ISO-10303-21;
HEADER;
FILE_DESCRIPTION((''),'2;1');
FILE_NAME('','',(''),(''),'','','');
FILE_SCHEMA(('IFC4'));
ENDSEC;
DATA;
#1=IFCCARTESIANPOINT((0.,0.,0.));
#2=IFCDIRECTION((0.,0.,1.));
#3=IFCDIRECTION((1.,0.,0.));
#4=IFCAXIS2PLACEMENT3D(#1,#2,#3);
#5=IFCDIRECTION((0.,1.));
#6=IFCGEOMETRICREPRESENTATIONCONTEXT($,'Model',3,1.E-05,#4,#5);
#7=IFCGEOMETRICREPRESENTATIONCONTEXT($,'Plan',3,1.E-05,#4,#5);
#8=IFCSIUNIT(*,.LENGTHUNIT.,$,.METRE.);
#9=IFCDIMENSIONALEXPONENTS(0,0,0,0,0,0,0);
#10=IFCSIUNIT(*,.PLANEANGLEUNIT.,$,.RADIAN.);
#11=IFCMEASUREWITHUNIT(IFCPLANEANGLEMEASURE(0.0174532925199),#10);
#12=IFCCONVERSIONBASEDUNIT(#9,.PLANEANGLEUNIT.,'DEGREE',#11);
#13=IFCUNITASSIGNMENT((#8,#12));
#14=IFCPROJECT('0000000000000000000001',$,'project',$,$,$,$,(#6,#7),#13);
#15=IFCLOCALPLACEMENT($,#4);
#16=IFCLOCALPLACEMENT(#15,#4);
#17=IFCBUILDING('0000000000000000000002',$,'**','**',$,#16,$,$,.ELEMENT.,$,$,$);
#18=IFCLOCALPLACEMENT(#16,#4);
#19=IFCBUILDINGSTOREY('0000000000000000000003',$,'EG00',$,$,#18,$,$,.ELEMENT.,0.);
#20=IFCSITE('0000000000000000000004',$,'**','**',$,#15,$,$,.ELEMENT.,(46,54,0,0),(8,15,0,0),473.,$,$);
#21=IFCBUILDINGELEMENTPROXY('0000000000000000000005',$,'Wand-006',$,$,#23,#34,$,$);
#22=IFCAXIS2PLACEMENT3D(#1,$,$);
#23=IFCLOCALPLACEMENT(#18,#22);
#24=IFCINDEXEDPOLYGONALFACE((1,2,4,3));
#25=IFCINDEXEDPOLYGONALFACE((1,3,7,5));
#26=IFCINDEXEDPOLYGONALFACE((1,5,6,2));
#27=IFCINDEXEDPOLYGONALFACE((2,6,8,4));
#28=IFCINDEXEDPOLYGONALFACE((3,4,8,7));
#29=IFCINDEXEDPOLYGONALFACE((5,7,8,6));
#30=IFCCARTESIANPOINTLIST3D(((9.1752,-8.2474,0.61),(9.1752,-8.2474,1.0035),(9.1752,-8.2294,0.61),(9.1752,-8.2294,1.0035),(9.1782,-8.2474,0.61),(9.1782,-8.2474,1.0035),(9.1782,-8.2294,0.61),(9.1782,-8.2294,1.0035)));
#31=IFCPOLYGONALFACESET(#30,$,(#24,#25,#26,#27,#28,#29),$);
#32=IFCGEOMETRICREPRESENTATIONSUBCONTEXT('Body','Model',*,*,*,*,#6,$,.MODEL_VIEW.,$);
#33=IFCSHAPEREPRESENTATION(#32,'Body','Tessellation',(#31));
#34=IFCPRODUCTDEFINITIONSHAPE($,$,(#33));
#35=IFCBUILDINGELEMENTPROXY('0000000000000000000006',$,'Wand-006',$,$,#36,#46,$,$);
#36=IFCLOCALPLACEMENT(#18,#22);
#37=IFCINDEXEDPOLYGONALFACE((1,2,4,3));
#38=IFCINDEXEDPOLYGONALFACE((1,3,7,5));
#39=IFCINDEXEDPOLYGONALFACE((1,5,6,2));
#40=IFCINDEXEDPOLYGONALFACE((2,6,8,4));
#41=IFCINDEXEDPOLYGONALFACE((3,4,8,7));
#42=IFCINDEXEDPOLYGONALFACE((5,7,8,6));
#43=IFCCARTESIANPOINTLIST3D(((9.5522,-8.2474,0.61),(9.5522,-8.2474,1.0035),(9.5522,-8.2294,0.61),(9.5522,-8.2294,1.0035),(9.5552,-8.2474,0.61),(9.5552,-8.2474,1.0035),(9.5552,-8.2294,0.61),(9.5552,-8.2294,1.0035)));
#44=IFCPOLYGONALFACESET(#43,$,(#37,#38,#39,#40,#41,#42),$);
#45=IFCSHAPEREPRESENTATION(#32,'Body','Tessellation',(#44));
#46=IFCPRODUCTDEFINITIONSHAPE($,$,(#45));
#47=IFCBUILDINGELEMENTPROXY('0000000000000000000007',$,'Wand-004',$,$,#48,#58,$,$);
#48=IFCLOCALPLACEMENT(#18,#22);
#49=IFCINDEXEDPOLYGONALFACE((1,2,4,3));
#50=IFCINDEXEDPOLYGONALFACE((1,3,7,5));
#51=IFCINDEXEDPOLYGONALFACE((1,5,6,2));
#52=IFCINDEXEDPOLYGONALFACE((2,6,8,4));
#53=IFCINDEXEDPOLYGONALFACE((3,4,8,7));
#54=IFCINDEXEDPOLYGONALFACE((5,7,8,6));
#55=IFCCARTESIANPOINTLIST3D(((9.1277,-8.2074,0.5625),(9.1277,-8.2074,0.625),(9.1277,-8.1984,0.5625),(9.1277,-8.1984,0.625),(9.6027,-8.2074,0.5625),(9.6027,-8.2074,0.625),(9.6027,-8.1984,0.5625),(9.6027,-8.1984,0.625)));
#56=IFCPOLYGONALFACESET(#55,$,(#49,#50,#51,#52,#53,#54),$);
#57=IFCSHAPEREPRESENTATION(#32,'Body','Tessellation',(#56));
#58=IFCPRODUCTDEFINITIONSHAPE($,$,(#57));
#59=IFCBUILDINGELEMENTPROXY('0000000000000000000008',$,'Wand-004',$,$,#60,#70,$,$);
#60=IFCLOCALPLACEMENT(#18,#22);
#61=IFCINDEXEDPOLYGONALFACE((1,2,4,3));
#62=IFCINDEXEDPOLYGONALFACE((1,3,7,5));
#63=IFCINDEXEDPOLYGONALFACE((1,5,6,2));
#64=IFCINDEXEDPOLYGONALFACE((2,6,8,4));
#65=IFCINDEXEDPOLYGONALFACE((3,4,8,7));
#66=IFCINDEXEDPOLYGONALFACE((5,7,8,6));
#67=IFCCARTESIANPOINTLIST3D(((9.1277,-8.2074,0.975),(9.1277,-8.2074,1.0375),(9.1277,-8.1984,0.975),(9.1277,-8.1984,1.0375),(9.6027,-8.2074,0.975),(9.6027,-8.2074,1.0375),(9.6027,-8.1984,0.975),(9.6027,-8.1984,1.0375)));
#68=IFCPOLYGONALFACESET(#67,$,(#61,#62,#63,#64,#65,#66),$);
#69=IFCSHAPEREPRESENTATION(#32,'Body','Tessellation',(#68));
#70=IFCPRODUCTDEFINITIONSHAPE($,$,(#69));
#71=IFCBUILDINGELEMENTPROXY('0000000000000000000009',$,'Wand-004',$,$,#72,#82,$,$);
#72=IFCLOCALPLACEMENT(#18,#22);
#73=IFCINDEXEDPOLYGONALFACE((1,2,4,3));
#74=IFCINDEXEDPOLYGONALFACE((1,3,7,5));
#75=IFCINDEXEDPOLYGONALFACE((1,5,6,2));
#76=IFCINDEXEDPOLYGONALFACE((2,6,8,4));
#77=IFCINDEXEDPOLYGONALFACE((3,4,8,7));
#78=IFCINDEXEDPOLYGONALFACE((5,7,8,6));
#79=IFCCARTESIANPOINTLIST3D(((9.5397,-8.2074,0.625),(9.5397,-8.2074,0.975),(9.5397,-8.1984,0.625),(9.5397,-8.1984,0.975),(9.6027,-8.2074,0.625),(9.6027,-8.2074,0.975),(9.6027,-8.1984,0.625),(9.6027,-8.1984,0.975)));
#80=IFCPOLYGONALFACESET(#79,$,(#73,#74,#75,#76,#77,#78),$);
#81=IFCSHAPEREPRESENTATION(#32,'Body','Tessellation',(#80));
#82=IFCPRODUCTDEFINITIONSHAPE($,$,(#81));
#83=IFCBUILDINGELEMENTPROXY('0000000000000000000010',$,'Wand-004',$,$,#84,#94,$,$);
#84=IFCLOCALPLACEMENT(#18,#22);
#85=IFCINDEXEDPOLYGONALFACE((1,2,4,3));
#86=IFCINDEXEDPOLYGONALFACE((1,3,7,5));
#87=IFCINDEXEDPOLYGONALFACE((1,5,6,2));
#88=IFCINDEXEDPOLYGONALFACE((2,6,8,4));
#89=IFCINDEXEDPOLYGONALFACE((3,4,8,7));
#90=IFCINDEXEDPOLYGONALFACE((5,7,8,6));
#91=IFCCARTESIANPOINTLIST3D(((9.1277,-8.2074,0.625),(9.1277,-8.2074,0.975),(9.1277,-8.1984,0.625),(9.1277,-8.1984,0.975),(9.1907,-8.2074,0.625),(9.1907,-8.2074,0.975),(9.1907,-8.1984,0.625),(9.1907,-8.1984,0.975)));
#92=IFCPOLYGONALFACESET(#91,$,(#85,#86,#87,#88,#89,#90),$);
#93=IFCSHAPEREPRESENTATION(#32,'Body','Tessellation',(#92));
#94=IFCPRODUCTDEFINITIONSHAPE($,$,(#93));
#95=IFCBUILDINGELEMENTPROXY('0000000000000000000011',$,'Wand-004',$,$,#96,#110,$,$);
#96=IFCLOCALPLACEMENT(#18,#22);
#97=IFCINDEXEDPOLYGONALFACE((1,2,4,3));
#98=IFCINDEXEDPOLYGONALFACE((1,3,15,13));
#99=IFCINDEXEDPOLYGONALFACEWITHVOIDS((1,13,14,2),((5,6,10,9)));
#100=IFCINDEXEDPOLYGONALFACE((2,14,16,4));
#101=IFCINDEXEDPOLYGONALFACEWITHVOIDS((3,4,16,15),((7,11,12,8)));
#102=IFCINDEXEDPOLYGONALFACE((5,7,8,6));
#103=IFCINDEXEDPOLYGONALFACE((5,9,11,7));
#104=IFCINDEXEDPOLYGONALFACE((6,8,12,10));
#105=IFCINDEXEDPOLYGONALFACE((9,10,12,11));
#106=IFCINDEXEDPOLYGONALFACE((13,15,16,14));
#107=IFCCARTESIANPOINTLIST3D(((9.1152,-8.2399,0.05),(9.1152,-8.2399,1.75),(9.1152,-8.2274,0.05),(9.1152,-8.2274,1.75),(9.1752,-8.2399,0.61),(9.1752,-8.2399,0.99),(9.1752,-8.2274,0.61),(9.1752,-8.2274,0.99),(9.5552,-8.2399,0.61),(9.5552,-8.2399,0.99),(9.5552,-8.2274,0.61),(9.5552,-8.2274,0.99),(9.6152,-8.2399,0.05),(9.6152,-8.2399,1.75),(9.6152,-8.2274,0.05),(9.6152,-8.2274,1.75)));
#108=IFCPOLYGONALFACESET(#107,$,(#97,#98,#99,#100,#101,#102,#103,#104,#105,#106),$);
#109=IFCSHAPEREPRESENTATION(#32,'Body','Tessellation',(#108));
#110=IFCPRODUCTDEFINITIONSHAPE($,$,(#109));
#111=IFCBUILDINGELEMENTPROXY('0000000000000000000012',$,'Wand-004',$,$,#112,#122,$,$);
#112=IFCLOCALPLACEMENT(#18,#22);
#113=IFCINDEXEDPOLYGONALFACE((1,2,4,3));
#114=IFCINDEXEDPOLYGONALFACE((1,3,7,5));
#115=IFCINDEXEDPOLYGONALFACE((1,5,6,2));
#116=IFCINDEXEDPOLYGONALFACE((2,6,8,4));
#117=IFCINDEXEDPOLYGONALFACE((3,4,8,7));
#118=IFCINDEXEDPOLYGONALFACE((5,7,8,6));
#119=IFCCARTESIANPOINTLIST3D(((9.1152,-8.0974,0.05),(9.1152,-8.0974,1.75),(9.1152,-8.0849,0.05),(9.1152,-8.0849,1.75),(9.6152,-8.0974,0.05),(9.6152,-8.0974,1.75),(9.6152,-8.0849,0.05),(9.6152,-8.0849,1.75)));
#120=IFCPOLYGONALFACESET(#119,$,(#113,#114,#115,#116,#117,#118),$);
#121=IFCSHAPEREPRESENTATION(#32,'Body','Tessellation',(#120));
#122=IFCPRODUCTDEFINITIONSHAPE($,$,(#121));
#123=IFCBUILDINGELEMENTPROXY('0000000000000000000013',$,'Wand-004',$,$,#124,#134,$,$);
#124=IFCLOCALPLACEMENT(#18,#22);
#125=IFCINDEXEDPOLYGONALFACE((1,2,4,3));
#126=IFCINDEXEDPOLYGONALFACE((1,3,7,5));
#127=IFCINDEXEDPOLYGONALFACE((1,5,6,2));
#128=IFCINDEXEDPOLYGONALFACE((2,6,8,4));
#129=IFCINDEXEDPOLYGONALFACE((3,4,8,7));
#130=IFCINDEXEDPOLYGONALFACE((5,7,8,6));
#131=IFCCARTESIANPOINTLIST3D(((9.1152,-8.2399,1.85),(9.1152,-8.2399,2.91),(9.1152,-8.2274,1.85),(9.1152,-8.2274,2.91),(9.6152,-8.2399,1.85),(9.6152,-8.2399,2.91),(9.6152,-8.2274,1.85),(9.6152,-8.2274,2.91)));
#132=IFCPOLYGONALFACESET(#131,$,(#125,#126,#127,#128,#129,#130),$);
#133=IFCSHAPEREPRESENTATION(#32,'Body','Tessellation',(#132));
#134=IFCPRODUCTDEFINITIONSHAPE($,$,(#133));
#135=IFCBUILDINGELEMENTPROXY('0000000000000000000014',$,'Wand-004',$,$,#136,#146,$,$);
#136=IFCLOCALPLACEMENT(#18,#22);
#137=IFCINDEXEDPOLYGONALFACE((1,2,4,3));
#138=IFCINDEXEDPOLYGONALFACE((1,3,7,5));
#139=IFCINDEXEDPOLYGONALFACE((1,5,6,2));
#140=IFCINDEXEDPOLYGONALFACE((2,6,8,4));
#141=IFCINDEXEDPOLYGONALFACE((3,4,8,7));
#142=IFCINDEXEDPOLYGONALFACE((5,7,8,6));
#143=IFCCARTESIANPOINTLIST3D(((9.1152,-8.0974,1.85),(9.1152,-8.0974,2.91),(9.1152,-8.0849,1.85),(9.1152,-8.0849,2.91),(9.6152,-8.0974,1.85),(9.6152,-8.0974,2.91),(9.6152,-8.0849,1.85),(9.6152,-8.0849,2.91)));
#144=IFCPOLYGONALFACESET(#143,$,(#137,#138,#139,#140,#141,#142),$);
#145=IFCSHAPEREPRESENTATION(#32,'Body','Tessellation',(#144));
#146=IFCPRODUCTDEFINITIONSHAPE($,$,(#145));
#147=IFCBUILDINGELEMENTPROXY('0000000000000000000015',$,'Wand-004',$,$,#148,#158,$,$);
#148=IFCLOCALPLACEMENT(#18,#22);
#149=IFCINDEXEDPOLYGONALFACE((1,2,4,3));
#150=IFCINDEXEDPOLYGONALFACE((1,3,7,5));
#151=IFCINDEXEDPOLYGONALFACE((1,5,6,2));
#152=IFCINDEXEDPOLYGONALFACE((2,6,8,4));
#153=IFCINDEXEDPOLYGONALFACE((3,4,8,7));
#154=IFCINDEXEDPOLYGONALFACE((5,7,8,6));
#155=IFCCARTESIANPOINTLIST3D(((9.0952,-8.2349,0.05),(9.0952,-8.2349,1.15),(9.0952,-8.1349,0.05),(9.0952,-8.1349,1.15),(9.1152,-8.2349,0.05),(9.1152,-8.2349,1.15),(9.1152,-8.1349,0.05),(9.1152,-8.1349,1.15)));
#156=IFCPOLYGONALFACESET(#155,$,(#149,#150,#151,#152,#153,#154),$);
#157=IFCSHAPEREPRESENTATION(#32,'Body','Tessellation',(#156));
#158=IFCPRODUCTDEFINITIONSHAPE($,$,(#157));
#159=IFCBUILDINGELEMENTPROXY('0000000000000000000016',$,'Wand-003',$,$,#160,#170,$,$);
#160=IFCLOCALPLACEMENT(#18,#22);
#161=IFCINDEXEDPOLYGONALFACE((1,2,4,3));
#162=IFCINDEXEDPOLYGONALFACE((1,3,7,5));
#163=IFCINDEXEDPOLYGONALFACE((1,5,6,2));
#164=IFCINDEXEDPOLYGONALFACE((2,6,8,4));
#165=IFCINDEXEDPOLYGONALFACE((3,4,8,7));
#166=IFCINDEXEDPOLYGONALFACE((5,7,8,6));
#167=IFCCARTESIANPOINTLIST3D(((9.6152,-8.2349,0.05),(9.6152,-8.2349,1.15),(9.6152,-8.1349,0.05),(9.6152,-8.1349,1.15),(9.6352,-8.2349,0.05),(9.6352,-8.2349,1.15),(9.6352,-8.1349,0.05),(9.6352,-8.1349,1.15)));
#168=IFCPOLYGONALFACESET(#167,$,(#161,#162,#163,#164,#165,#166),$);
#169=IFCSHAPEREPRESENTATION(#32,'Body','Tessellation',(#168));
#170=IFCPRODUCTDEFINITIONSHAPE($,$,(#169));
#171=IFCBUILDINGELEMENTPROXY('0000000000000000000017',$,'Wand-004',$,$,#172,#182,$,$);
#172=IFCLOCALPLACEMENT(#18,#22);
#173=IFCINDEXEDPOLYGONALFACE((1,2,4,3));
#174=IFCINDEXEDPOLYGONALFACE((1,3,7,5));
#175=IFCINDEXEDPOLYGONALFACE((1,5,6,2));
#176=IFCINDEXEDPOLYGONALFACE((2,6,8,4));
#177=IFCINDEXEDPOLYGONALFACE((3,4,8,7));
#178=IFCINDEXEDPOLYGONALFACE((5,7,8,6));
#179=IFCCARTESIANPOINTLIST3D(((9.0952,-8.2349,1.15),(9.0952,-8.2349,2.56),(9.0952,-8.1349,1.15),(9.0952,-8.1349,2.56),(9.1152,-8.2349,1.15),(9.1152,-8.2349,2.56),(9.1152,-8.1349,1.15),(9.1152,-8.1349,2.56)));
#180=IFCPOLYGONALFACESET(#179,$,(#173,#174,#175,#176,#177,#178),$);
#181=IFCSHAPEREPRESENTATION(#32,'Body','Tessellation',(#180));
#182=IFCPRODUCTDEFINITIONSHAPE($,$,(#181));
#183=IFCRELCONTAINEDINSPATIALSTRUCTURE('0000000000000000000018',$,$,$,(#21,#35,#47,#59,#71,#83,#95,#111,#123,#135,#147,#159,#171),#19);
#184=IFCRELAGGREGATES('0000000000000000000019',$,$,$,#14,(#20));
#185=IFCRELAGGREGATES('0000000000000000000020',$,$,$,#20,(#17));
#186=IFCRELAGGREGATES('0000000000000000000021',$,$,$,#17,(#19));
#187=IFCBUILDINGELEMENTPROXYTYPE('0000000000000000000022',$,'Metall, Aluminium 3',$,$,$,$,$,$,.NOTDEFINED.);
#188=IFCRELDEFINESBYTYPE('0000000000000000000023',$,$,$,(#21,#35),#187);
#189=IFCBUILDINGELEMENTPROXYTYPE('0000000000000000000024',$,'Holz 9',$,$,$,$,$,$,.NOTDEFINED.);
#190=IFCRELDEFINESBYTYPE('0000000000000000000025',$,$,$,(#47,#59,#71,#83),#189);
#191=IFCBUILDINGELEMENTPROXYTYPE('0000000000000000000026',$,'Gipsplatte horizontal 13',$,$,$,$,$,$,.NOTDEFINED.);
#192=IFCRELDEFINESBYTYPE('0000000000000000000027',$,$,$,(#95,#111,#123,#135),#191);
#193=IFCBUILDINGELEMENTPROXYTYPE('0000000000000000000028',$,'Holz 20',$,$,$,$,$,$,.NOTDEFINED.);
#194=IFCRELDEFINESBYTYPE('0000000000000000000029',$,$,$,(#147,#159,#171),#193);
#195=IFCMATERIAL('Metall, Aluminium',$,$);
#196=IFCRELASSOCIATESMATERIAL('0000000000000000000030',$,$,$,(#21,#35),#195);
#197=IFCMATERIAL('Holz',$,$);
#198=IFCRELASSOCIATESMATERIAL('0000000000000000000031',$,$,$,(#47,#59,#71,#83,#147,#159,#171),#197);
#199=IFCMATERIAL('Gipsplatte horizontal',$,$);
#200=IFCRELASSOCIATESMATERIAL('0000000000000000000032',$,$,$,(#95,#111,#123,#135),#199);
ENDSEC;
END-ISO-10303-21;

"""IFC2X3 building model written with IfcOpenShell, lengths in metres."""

from ifc_helpers import new_model, entity, si_unit, converted_unit, direction, frame, origin_with_axes, origin_2d_with_axis, place, context, subcontext, project, spatial, polyline, rectangle, outline, extrude, material, type_object, element, save


model = new_model("IFC2X3")

# Units and contexts
model_context = context("Model", 3, precision=1e-05, world=origin_with_axes(), true_north=direction((0.0, 1.0)))
plan_context = context("Plan", 3, precision=1e-05, world=origin_with_axes(), true_north=direction((0.0, 1.0)))
body_context = subcontext(model_context, "Body", "Model", "MODEL_VIEW")
ifc_project = project(units=[si_unit("LENGTHUNIT", "METRE"), converted_unit("PLANEANGLEUNIT", "DEGREE", entity("IfcPlaneAngleMeasure", 0.0174532925199), si_unit("PLANEANGLEUNIT", "RADIAN"), dimensions=[0, 0, 0, 0, 0, 0, 0])], contexts=[model_context, plan_context])

# Site, building, storey
site_placement = place(None, origin_with_axes())
site = spatial("IfcSite", under=ifc_project, at=site_placement, Name="**", Description="**", CompositionType="ELEMENT", RefLatitude=(46, 54, 0, 0), RefLongitude=(8, 15, 0, 0), RefElevation=473.0)
building_placement = place(site_placement, origin_with_axes())
building = spatial("IfcBuilding", under=site, at=building_placement, Name="**", Description="**", CompositionType="ELEMENT")
storey_placement = place(building_placement, origin_with_axes())
storey = spatial("IfcBuildingStorey", under=building, at=storey_placement, Name="EG00", CompositionType="ELEMENT", Elevation=0.0)

# Building element proxies
ifc_material_1 = material(Name="Holz")
ifc_material_2 = material(Name="Metall, Aluminium")
building_element_proxy_type_1 = type_object("IfcBuildingElementProxyType", Name="Metall, Aluminium 3", PredefinedType="NOTDEFINED")
proxy_1_placement = place(storey_placement, frame((9.1752, -8.2294, 0.61), z_axis=(0.0, 0.0, 1.0), x_axis=(0.0, -1.0, 0.0)))
element("IfcBuildingElementProxy", 1, at=proxy_1_placement, inside=storey, type_object=building_element_proxy_type_1, material=ifc_material_2, Name="Wand-006", context=body_context, shape_type="SweptSolid", body=[
    extrude(outline(polyline([(0.0, 0.0), (0.018, 0.0), (0.018, 0.003), (0.0, 0.003), (0.0, 0.0)])), origin_with_axes(), (0.0, 0.0, 1.0), 0.3935),
])
proxy_2_placement = place(storey_placement, frame((9.5552, -8.2294, 0.61), z_axis=(0.0, 0.0, 1.0), x_axis=(0.0, -1.0, 0.0)))
element("IfcBuildingElementProxy", 2, at=proxy_2_placement, inside=storey, type_object=building_element_proxy_type_1, material=ifc_material_2, Name="Wand-006", context=body_context, shape_type="SweptSolid", body=[
    extrude(outline(polyline([(0.0, -0.003), (0.018, -0.003), (0.018, 0.0), (0.0, 0.0), (0.0, -0.003)])), origin_with_axes(), (0.0, 0.0, 1.0), 0.3935),
])
building_element_proxy_type_2 = type_object("IfcBuildingElementProxyType", Name="Holz 9", PredefinedType="NOTDEFINED")
for number, where, z_axis, x_axis, name in (
    (3, (9.6027, -8.2074, 0.5625), (0.0, 0.0, 1.0), (-1.0, 0.0, 0.0), "Wand-004"),
    (4, (9.6027, -8.2074, 0.975), (0.0, 0.0, 1.0), (-1.0, 0.0, 0.0), "Wand-004"),
):
    element("IfcBuildingElementProxy", number, at=place(storey_placement, frame(where, z_axis=z_axis, x_axis=x_axis)), inside=storey, type_object=building_element_proxy_type_2, material=ifc_material_1, Name=name, context=body_context, shape_type="SweptSolid", body=[
        extrude(outline(polyline([(0.0, -0.009), (0.475, -0.009), (0.475, 0.0), (0.0, 0.0), (0.0, -0.009)])), origin_with_axes(), (0.0, 0.0, 1.0), 0.0625),
    ])
for number, where, z_axis, x_axis, name in (
    (5, (9.5397, -8.2074, 0.625), (0.0, 0.0, 1.0), (1.0, 0.0, 0.0), "Wand-004"),
    (6, (9.1277, -8.2074, 0.625), (0.0, 0.0, 1.0), (1.0, 0.0, 0.0), "Wand-004"),
):
    element("IfcBuildingElementProxy", number, at=place(storey_placement, frame(where, z_axis=z_axis, x_axis=x_axis)), inside=storey, type_object=building_element_proxy_type_2, material=ifc_material_1, Name=name, context=body_context, shape_type="SweptSolid", body=[
        extrude(outline(polyline([(0.0, 0.0), (0.063, 0.0), (0.063, 0.009), (0.0, 0.009), (0.0, 0.0)])), origin_with_axes(), (0.0, 0.0, 1.0), 0.35),
    ])

# Building element proxy, opening
ifc_material_3 = material(Name="Gipsplatte horizontal")
building_element_proxy_type_3 = type_object("IfcBuildingElementProxyType", Name="Gipsplatte horizontal 13", PredefinedType="NOTDEFINED")
proxy_3_placement = place(storey_placement, frame((9.1152, -8.2399, 0.05), z_axis=(0.0, 0.0, 1.0), x_axis=(1.0, 0.0, 0.0)))
proxy_3 = element("IfcBuildingElementProxy", 7, at=proxy_3_placement, inside=storey, type_object=building_element_proxy_type_3, material=ifc_material_3, Name="Wand-004", context=body_context, shape_type="SweptSolid", body=[
    extrude(outline(polyline([(0.0, 0.0), (0.5, 0.0), (0.5, 0.0125), (0.0, 0.0125), (0.0, 0.0)])), origin_with_axes(), (0.0, 0.0, 1.0), 1.7),
])
opening_placement = place(proxy_3_placement, frame((-9.1152, 8.2399, -0.05), z_axis=(0.0, 0.0, 1.0), x_axis=(1.0, 0.0, 0.0)))
element("IfcOpeningElement", 8, at=opening_placement, cuts=proxy_3, context=body_context, shape_type="SweptSolid", body=[
    extrude(rectangle(XDim=0.38, YDim=0.38, at=origin_2d_with_axis()), frame((9.3652, -8.2524, 0.8), z_axis=(0.0, -1.0, 0.0), x_axis=(1.0, 0.0, 0.0)), (0.0, 0.0, -1.0), 0.0375),
])

# Building element proxies
proxy_4_placement = place(storey_placement, frame((9.1152, -8.0849, 0.05), z_axis=(0.0, 0.0, 1.0), x_axis=(1.0, 0.0, 0.0)))
element("IfcBuildingElementProxy", 9, at=proxy_4_placement, inside=storey, type_object=building_element_proxy_type_3, material=ifc_material_3, Name="Wand-004", context=body_context, shape_type="SweptSolid", body=[
    extrude(outline(polyline([(0.0, -0.0125), (0.5, -0.0125), (0.5, 0.0), (0.0, 0.0), (0.0, -0.0125)])), origin_with_axes(), (0.0, 0.0, 1.0), 1.7),
])
proxy_5_placement = place(storey_placement, frame((9.1152, -8.2399, 1.85), z_axis=(0.0, 0.0, 1.0), x_axis=(1.0, 0.0, 0.0)))
element("IfcBuildingElementProxy", 10, at=proxy_5_placement, inside=storey, type_object=building_element_proxy_type_3, material=ifc_material_3, Name="Wand-004", context=body_context, shape_type="SweptSolid", body=[
    extrude(outline(polyline([(0.0, 0.0), (0.5, 0.0), (0.5, 0.0125), (0.0, 0.0125), (0.0, 0.0)])), origin_with_axes(), (0.0, 0.0, 1.0), 1.06),
])
proxy_6_placement = place(storey_placement, frame((9.1152, -8.0849, 1.85), z_axis=(0.0, 0.0, 1.0), x_axis=(1.0, 0.0, 0.0)))
element("IfcBuildingElementProxy", 11, at=proxy_6_placement, inside=storey, type_object=building_element_proxy_type_3, material=ifc_material_3, Name="Wand-004", context=body_context, shape_type="SweptSolid", body=[
    extrude(outline(polyline([(0.0, -0.0125), (0.5, -0.0125), (0.5, 0.0), (0.0, 0.0), (0.0, -0.0125)])), origin_with_axes(), (0.0, 0.0, 1.0), 1.06),
])
building_element_proxy_type_4 = type_object("IfcBuildingElementProxyType", Name="Holz 20", PredefinedType="NOTDEFINED")
proxy_7_placement = place(storey_placement, frame((9.0952, -8.1349, 0.05), z_axis=(0.0, 0.0, 1.0), x_axis=(0.0, -1.0, 0.0)))
element("IfcBuildingElementProxy", 12, at=proxy_7_placement, inside=storey, type_object=building_element_proxy_type_4, material=ifc_material_1, Name="Wand-004", context=body_context, shape_type="SweptSolid", body=[
    extrude(outline(polyline([(0.0, 0.0), (0.1, 0.0), (0.1, 0.02), (0.0, 0.02), (0.0, 0.0)])), origin_with_axes(), (0.0, 0.0, 1.0), 1.1),
])
proxy_8_placement = place(storey_placement, frame((9.6352, -8.1349, 0.05), z_axis=(0.0, 0.0, 1.0), x_axis=(0.0, -1.0, 0.0)))
element("IfcBuildingElementProxy", 13, at=proxy_8_placement, inside=storey, type_object=building_element_proxy_type_4, material=ifc_material_1, Name="Wand-003", context=body_context, shape_type="SweptSolid", body=[
    extrude(outline(polyline([(0.0, -0.02), (0.1, -0.02), (0.1, 0.0), (0.0, 0.0), (0.0, -0.02)])), origin_with_axes(), (0.0, 0.0, 1.0), 1.1),
])
proxy_9_placement = place(storey_placement, frame((9.0952, -8.1349, 1.15), z_axis=(0.0, 0.0, 1.0), x_axis=(0.0, -1.0, 0.0)))
element("IfcBuildingElementProxy", 14, at=proxy_9_placement, inside=storey, type_object=building_element_proxy_type_4, material=ifc_material_1, Name="Wand-004", context=body_context, shape_type="SweptSolid", body=[
    extrude(outline(polyline([(0.0, 0.0), (0.1, 0.0), (0.1, 0.02), (0.0, 0.02), (0.0, 0.0)])), origin_with_axes(), (0.0, 0.0, 1.0), 1.41),
])

save(model, "model.ifc")
